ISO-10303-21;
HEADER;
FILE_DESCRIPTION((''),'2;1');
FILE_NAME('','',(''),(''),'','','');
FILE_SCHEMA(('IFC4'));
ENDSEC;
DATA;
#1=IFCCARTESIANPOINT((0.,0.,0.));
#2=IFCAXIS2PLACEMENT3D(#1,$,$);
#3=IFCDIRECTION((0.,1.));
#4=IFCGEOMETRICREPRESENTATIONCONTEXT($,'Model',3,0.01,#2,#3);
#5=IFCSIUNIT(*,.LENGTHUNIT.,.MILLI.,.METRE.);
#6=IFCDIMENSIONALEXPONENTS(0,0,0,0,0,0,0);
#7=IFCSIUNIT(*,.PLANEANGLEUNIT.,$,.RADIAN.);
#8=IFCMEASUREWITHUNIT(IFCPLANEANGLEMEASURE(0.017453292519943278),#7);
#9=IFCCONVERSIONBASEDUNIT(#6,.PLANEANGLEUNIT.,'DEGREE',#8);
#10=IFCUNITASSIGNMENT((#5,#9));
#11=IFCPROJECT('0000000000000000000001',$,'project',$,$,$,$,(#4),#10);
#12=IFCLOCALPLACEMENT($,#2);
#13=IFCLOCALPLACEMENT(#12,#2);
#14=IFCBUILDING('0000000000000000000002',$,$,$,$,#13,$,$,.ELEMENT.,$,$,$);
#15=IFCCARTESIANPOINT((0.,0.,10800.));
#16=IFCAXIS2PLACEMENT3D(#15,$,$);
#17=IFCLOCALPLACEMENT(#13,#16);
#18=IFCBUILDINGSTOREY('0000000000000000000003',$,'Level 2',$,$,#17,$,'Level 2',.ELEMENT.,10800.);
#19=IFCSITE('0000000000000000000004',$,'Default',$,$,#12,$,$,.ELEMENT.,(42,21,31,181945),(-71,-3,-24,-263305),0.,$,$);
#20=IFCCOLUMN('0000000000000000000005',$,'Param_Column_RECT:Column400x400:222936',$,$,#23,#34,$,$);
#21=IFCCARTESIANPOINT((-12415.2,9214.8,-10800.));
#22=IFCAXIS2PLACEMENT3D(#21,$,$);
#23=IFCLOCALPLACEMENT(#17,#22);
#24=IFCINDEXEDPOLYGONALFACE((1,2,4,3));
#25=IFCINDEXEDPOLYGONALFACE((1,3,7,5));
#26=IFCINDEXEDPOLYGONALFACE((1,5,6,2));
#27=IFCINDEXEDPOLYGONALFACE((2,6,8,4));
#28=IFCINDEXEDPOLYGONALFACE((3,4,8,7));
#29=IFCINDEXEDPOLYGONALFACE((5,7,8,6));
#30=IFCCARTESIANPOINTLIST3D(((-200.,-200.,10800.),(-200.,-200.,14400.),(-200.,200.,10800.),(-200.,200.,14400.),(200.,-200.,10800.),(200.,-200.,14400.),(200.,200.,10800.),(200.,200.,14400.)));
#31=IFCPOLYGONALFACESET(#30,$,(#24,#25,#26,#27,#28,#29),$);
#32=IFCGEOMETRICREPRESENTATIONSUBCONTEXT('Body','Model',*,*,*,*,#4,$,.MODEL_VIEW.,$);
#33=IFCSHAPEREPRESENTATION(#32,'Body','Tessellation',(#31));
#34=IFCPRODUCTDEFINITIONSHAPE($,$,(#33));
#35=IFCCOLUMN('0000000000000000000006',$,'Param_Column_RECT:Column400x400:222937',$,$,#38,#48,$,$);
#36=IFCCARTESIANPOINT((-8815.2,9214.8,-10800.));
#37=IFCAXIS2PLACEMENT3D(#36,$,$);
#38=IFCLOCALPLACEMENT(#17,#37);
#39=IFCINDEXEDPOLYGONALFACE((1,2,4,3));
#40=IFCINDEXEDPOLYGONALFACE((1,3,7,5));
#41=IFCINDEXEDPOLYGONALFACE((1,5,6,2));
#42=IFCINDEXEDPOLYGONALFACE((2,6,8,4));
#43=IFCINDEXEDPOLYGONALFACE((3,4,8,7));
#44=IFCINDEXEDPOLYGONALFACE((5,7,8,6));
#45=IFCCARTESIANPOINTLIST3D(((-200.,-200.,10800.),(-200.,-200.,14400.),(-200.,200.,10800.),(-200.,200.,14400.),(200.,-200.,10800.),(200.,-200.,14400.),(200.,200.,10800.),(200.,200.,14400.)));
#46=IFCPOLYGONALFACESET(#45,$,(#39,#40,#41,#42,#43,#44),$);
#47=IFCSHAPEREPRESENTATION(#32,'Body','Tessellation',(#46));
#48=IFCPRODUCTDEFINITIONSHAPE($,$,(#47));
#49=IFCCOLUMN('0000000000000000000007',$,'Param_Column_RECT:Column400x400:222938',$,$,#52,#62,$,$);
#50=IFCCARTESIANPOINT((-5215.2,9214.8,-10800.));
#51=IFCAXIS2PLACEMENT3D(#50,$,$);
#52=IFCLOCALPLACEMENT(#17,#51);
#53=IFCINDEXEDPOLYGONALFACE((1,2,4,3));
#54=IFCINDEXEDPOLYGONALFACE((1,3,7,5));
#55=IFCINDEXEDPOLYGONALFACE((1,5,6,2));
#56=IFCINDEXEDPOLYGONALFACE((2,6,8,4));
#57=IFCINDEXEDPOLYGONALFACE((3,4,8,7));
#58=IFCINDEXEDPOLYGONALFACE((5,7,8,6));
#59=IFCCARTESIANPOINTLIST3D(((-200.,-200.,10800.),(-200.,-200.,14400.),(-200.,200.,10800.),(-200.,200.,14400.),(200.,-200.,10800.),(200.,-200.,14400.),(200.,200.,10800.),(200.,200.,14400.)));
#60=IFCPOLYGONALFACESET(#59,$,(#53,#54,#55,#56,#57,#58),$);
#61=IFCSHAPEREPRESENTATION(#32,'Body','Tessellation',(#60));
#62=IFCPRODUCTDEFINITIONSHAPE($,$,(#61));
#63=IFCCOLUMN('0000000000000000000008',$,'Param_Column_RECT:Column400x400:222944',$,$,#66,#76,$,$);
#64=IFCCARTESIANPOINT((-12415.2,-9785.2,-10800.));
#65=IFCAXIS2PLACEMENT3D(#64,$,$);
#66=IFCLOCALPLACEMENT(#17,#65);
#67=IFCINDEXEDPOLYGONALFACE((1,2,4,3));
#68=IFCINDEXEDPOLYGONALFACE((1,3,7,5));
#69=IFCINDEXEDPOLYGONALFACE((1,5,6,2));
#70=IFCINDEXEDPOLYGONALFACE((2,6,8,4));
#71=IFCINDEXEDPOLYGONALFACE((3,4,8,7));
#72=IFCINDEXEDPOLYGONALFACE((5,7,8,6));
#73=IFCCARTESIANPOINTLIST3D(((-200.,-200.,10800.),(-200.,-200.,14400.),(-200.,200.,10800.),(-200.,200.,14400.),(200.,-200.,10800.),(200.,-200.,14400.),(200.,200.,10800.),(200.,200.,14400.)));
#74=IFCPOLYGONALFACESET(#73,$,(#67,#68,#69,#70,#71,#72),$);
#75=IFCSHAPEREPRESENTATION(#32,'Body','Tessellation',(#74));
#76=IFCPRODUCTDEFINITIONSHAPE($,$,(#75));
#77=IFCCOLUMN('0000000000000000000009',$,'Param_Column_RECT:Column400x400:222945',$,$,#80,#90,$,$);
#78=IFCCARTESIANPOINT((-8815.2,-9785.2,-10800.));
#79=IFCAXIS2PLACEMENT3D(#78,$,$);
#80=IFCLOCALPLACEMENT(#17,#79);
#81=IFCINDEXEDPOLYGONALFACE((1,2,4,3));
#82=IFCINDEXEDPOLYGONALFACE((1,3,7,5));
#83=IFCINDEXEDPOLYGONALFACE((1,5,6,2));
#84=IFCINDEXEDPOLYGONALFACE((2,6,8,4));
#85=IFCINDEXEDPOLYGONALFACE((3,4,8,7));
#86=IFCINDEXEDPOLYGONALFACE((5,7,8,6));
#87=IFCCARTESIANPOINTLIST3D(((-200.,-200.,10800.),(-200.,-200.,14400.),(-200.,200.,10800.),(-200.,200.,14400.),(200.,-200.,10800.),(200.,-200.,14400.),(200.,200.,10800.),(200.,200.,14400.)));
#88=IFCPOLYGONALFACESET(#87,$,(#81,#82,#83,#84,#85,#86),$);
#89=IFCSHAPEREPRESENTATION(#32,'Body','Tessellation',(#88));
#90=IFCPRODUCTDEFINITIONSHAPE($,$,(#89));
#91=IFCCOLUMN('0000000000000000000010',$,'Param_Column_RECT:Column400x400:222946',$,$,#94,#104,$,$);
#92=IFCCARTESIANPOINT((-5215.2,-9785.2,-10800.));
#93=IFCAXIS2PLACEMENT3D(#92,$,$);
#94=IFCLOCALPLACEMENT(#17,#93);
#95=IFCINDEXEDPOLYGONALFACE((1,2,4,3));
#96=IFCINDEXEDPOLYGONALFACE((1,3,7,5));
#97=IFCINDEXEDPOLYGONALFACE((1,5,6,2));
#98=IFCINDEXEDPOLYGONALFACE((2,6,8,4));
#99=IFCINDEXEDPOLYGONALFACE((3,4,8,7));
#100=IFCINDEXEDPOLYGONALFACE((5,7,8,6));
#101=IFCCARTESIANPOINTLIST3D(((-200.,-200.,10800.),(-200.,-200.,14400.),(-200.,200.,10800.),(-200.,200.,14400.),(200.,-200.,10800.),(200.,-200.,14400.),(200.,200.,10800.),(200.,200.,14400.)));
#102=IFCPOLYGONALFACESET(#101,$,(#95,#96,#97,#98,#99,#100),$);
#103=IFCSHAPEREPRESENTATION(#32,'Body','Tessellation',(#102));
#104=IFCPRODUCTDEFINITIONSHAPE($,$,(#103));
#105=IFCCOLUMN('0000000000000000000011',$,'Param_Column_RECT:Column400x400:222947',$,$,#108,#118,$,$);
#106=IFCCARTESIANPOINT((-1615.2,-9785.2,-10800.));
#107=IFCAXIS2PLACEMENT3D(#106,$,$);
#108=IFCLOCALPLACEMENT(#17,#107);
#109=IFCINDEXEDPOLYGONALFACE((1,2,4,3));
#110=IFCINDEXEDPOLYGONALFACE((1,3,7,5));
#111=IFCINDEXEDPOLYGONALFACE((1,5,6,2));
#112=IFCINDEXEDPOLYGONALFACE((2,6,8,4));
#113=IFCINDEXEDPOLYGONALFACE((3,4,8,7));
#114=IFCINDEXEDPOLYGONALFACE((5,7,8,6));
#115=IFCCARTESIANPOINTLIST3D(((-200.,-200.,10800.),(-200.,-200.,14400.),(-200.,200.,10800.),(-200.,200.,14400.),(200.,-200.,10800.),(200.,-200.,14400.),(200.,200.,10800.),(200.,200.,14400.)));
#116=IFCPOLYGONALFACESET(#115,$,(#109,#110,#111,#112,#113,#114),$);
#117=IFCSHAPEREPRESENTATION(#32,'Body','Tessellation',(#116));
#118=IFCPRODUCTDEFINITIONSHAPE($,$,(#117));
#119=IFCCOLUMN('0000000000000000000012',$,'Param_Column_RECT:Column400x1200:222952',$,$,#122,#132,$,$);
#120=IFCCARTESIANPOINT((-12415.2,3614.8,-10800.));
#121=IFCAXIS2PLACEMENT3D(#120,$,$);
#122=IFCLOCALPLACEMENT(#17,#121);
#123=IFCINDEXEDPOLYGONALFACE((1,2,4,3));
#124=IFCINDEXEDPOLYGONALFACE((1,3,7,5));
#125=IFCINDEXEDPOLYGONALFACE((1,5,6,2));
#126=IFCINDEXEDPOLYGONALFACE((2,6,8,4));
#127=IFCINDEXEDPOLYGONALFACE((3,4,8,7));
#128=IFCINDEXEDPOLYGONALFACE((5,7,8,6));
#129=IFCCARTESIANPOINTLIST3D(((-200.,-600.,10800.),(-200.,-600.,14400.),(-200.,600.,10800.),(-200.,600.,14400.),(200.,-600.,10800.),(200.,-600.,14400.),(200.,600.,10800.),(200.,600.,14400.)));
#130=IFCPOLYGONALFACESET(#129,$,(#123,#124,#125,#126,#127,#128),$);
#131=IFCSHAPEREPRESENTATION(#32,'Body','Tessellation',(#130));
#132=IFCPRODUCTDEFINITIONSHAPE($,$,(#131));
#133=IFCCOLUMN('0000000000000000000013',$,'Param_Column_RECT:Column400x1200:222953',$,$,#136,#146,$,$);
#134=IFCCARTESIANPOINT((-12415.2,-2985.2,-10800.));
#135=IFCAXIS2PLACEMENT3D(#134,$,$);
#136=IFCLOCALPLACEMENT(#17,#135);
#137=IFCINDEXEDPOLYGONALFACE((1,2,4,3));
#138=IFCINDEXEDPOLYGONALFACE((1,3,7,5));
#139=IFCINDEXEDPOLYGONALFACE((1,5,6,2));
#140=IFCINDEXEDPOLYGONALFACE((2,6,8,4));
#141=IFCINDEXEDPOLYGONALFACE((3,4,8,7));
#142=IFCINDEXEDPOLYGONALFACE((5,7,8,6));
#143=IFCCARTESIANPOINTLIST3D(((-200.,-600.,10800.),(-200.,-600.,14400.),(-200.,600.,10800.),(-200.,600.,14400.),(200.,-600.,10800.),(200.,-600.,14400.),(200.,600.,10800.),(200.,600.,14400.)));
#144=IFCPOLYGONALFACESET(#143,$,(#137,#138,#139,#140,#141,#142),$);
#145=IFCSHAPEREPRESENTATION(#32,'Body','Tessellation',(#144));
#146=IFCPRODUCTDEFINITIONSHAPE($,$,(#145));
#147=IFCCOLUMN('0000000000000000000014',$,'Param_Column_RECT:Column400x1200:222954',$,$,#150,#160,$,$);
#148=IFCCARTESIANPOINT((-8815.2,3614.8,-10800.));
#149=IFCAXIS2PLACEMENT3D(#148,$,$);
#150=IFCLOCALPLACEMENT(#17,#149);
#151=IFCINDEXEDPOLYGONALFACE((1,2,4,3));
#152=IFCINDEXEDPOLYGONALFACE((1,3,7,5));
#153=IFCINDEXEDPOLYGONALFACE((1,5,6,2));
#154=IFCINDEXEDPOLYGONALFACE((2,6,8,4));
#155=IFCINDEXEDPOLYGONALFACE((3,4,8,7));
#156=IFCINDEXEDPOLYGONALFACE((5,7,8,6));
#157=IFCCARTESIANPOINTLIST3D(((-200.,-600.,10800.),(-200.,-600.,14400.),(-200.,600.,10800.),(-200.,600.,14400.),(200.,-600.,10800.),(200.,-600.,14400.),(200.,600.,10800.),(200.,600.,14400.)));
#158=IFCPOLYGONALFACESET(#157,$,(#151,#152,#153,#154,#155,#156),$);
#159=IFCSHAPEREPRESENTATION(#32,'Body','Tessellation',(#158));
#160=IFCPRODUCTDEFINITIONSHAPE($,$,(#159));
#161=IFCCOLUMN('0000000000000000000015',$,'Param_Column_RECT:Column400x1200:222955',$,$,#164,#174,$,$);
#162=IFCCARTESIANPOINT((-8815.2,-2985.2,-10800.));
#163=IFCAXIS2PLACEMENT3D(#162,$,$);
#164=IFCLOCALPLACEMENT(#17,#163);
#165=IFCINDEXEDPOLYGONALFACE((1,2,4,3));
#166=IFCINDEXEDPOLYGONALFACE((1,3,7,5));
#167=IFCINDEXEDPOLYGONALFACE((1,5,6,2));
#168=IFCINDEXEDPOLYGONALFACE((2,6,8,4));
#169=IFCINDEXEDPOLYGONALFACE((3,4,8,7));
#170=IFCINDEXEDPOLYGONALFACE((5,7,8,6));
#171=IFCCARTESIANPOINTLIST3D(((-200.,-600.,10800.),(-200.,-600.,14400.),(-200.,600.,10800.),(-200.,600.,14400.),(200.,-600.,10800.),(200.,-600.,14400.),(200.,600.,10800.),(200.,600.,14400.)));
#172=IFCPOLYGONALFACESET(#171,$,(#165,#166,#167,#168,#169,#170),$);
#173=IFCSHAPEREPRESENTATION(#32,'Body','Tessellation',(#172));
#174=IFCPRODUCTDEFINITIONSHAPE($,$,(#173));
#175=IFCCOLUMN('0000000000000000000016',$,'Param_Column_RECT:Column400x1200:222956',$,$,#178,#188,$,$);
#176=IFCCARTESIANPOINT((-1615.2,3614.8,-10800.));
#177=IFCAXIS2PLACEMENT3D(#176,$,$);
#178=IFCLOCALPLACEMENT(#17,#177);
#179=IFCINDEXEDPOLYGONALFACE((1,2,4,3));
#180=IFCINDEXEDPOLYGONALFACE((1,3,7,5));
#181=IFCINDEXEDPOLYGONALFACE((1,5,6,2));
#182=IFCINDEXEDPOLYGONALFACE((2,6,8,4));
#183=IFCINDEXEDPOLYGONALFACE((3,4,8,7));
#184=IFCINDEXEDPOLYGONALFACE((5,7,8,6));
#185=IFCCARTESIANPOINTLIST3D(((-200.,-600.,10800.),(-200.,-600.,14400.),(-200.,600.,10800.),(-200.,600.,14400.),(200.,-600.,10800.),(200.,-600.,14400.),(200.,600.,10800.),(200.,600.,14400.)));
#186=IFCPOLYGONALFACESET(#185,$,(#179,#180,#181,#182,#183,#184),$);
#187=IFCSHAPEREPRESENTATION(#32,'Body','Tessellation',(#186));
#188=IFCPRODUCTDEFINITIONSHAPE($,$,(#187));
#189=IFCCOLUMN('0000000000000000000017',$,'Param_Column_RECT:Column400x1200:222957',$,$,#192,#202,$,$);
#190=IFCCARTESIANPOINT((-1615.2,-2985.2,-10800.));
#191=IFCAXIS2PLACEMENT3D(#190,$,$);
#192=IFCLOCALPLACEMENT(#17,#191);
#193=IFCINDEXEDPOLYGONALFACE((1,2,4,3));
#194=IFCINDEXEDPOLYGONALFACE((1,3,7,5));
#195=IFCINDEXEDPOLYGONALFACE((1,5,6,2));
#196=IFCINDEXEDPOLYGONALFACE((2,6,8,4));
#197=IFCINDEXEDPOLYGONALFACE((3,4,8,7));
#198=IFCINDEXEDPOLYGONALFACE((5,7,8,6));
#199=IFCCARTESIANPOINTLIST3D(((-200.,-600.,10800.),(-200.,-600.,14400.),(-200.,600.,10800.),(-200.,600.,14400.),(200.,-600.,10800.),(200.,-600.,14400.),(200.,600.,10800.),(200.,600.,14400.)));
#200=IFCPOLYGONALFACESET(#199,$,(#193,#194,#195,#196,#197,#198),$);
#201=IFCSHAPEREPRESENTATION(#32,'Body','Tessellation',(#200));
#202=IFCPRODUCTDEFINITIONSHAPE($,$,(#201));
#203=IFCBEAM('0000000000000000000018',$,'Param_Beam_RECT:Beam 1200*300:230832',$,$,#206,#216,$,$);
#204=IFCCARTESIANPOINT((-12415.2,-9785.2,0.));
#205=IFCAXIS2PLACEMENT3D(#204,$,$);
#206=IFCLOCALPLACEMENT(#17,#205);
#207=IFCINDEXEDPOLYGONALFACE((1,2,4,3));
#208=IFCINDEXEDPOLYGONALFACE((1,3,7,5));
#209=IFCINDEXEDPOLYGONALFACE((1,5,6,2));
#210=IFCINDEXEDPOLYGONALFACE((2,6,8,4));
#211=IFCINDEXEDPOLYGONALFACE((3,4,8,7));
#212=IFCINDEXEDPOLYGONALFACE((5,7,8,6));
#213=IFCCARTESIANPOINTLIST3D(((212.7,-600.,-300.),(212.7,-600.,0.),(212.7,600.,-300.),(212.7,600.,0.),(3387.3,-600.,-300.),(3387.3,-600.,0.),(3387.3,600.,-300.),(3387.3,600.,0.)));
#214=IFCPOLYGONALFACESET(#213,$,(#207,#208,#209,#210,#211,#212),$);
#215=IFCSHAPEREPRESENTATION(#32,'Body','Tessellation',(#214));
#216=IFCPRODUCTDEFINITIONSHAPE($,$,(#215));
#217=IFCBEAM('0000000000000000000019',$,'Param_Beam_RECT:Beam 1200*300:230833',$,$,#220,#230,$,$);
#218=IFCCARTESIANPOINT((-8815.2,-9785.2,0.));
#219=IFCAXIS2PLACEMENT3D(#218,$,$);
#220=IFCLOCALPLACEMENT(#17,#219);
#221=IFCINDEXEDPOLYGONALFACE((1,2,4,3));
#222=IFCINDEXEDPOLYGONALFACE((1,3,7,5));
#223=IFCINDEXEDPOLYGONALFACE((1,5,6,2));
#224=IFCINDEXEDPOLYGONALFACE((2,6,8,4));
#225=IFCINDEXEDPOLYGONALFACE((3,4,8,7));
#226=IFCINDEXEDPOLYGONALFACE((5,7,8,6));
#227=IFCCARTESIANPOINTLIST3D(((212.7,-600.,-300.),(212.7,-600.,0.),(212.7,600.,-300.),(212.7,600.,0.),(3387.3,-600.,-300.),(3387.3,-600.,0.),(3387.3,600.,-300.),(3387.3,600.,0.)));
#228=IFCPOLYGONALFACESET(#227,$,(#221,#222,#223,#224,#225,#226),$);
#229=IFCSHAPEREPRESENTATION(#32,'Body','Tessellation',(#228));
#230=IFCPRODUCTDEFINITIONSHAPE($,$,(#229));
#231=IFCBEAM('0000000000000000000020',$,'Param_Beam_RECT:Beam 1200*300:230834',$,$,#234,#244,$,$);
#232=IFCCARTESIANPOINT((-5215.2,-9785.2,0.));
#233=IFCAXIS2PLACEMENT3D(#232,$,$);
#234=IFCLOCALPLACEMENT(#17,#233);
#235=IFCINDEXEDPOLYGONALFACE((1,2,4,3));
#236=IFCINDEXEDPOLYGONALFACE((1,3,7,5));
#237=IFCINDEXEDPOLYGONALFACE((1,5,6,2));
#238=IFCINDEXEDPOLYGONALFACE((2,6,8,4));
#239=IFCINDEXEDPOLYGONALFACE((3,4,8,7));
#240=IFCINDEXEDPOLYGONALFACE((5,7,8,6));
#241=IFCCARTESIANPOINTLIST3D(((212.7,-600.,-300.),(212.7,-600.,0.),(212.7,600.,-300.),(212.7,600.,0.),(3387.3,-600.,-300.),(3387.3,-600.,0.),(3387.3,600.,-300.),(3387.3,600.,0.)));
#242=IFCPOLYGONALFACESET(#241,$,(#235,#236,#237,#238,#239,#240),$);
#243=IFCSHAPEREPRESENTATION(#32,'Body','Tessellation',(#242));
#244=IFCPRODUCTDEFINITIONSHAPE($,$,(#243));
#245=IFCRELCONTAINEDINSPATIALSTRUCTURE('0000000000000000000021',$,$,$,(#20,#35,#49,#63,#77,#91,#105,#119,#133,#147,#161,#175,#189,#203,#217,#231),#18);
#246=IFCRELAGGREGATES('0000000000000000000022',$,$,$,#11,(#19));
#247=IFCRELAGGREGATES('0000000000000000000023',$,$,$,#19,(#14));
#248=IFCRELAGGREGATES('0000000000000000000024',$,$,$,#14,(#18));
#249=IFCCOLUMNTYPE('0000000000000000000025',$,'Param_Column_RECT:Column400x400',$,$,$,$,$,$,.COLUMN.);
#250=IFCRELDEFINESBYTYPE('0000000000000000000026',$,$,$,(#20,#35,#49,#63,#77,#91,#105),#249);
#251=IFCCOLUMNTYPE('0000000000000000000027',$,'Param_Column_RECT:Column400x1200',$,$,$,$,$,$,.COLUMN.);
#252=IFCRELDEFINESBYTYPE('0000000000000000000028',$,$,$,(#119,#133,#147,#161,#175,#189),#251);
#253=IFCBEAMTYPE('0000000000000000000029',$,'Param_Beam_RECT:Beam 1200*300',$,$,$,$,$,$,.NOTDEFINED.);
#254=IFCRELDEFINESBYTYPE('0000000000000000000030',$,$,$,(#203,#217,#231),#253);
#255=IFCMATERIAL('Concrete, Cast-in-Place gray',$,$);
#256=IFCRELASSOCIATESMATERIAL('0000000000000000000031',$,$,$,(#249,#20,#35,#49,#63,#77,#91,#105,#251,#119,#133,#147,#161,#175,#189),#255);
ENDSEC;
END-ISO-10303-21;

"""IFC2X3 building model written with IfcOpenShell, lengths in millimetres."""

from ifc_helpers import new_model, entity, si_unit, converted_unit, direction, frame, frame_2d, origin, origin_2d_with_axis, place, context, subcontext, project, spatial, rectangle, extrude, source, transform, mapped, material, type_object, type_shapes, element, save


model = new_model("IFC2X3")

# Units and contexts
model_context = context("Model", 3, precision=0.01, world=origin(), true_north=direction((0.0, 1.0)))
body_context = subcontext(model_context, "Body", "Model", "MODEL_VIEW")
ifc_project = project(units=[si_unit("LENGTHUNIT", "METRE", prefix="MILLI"), converted_unit("PLANEANGLEUNIT", "DEGREE", entity("IfcPlaneAngleMeasure", 0.017453292519943278), si_unit("PLANEANGLEUNIT", "RADIAN"), dimensions=[0, 0, 0, 0, 0, 0, 0])], contexts=[model_context])

# Site, building, storey
site_placement = place(None, origin())
site = spatial("IfcSite", under=ifc_project, at=site_placement, Name="Default", CompositionType="ELEMENT", RefLatitude=(42, 21, 31, 181945), RefLongitude=(-71, -3, -24, -263305), RefElevation=0.0)
building_placement = place(site_placement, origin())
building = spatial("IfcBuilding", under=site, at=building_placement, CompositionType="ELEMENT")
storey_placement = place(building_placement, frame((0.0, 0.0, 10800.0)))
storey = spatial("IfcBuildingStorey", under=building, at=storey_placement, Name="Level 2", LongName="Level 2", CompositionType="ELEMENT", Elevation=10800.0)

# Columns
ifc_material_1 = material(Name="Concrete, Cast-in-Place gray")
column_type_1 = type_object("IfcColumnType", Name="Param_Column_RECT:Column400x400", PredefinedType="COLUMN", material=ifc_material_1)
shared_shape_1 = source(origin(), body_context, "Body", "SweptSolid", [
    extrude(rectangle(XDim=400.0, YDim=400.0, at=origin_2d_with_axis()), frame((0.0, 0.0, 10800.0), z_axis=(0.0, 0.0, 1.0), x_axis=(-1.0, 0.0, 0.0)), (0.0, 0.0, 1.0), 3600.0),
])
type_shapes(column_type_1, [shared_shape_1])
for number, where, name in (
    (1, (-12415.2, 9214.8, -10800.0), "Param_Column_RECT:Column400x400:222936"),
    (2, (-8815.2, 9214.8, -10800.0), "Param_Column_RECT:Column400x400:222937"),
    (3, (-5215.2, 9214.8, -10800.0), "Param_Column_RECT:Column400x400:222938"),
    (4, (-12415.2, -9785.2, -10800.0), "Param_Column_RECT:Column400x400:222944"),
    (5, (-8815.2, -9785.2, -10800.0), "Param_Column_RECT:Column400x400:222945"),
    (6, (-5215.2, -9785.2, -10800.0), "Param_Column_RECT:Column400x400:222946"),
    (7, (-1615.2, -9785.2, -10800.0), "Param_Column_RECT:Column400x400:222947"),
):
    element("IfcColumn", number, at=place(storey_placement, frame(where)), inside=storey, type_object=column_type_1, material=ifc_material_1, Name=name, context=body_context, shape_type="MappedRepresentation", body=[
        mapped(shared_shape_1, transform((0.0, 0.0, 0.0), scale=1.0)),
    ])
column_type_2 = type_object("IfcColumnType", Name="Param_Column_RECT:Column400x1200", PredefinedType="COLUMN", material=ifc_material_1)
shared_shape_2 = source(origin(), body_context, "Body", "SweptSolid", [
    extrude(rectangle(XDim=400.0, YDim=1200.0, at=origin_2d_with_axis()), frame((0.0, 0.0, 10800.0), z_axis=(0.0, 0.0, 1.0), x_axis=(-1.0, 0.0, 0.0)), (0.0, 0.0, 1.0), 3600.0),
])
type_shapes(column_type_2, [shared_shape_2])
for number, where, name in (
    (8, (-12415.2, 3614.8, -10800.0), "Param_Column_RECT:Column400x1200:222952"),
    (9, (-12415.2, -2985.2, -10800.0), "Param_Column_RECT:Column400x1200:222953"),
    (10, (-8815.2, 3614.8, -10800.0), "Param_Column_RECT:Column400x1200:222954"),
    (11, (-8815.2, -2985.2, -10800.0), "Param_Column_RECT:Column400x1200:222955"),
    (12, (-1615.2, 3614.8, -10800.0), "Param_Column_RECT:Column400x1200:222956"),
    (13, (-1615.2, -2985.2, -10800.0), "Param_Column_RECT:Column400x1200:222957"),
):
    element("IfcColumn", number, at=place(storey_placement, frame(where)), inside=storey, type_object=column_type_2, material=ifc_material_1, Name=name, context=body_context, shape_type="MappedRepresentation", body=[
        mapped(shared_shape_2, transform((0.0, 0.0, 0.0), scale=1.0)),
    ])

# Beams
beam_type_1 = type_object("IfcBeamType", Name="Param_Beam_RECT:Beam 1200*300", PredefinedType="NOTDEFINED")
beam_1_placement = place(storey_placement, frame((-12415.2, -9785.2, 0.0)))
element("IfcBeam", 14, at=beam_1_placement, inside=storey, type_object=beam_type_1, Name="Param_Beam_RECT:Beam 1200*300:230832", context=body_context, shape_type="SweptSolid", body=[
    extrude(rectangle(XDim=300.0, YDim=1200.0, at=frame_2d((0.0, 0.0), x_axis=(1.0, 0.0))), frame((212.7, 0.0, -150.0), z_axis=(1.0, 0.0, 0.0), x_axis=(0.0, 0.0, -1.0)), (0.0, 0.0, 1.0), 3174.6),
])
beam_2_placement = place(storey_placement, frame((-8815.2, -9785.2, 0.0)))
element("IfcBeam", 15, at=beam_2_placement, inside=storey, type_object=beam_type_1, Name="Param_Beam_RECT:Beam 1200*300:230833", context=body_context, shape_type="SweptSolid", body=[
    extrude(rectangle(XDim=300.0, YDim=1200.0, at=frame_2d((0.0, 0.0), x_axis=(1.0, 0.0))), frame((212.7, 0.0, -150.0), z_axis=(1.0, 0.0, 0.0), x_axis=(0.0, 0.0, -1.0)), (0.0, 0.0, 1.0), 3174.6),
])
beam_3_placement = place(storey_placement, frame((-5215.2, -9785.2, 0.0)))
element("IfcBeam", 16, at=beam_3_placement, inside=storey, type_object=beam_type_1, Name="Param_Beam_RECT:Beam 1200*300:230834", context=body_context, shape_type="SweptSolid", body=[
    extrude(rectangle(XDim=300.0, YDim=1200.0, at=frame_2d((0.0, 0.0), x_axis=(1.0, 0.0))), frame((212.7, 0.0, -150.0), z_axis=(1.0, 0.0, 0.0), x_axis=(0.0, 0.0, -1.0)), (0.0, 0.0, 1.0), 3174.6),
])

save(model, "model.ifc")
